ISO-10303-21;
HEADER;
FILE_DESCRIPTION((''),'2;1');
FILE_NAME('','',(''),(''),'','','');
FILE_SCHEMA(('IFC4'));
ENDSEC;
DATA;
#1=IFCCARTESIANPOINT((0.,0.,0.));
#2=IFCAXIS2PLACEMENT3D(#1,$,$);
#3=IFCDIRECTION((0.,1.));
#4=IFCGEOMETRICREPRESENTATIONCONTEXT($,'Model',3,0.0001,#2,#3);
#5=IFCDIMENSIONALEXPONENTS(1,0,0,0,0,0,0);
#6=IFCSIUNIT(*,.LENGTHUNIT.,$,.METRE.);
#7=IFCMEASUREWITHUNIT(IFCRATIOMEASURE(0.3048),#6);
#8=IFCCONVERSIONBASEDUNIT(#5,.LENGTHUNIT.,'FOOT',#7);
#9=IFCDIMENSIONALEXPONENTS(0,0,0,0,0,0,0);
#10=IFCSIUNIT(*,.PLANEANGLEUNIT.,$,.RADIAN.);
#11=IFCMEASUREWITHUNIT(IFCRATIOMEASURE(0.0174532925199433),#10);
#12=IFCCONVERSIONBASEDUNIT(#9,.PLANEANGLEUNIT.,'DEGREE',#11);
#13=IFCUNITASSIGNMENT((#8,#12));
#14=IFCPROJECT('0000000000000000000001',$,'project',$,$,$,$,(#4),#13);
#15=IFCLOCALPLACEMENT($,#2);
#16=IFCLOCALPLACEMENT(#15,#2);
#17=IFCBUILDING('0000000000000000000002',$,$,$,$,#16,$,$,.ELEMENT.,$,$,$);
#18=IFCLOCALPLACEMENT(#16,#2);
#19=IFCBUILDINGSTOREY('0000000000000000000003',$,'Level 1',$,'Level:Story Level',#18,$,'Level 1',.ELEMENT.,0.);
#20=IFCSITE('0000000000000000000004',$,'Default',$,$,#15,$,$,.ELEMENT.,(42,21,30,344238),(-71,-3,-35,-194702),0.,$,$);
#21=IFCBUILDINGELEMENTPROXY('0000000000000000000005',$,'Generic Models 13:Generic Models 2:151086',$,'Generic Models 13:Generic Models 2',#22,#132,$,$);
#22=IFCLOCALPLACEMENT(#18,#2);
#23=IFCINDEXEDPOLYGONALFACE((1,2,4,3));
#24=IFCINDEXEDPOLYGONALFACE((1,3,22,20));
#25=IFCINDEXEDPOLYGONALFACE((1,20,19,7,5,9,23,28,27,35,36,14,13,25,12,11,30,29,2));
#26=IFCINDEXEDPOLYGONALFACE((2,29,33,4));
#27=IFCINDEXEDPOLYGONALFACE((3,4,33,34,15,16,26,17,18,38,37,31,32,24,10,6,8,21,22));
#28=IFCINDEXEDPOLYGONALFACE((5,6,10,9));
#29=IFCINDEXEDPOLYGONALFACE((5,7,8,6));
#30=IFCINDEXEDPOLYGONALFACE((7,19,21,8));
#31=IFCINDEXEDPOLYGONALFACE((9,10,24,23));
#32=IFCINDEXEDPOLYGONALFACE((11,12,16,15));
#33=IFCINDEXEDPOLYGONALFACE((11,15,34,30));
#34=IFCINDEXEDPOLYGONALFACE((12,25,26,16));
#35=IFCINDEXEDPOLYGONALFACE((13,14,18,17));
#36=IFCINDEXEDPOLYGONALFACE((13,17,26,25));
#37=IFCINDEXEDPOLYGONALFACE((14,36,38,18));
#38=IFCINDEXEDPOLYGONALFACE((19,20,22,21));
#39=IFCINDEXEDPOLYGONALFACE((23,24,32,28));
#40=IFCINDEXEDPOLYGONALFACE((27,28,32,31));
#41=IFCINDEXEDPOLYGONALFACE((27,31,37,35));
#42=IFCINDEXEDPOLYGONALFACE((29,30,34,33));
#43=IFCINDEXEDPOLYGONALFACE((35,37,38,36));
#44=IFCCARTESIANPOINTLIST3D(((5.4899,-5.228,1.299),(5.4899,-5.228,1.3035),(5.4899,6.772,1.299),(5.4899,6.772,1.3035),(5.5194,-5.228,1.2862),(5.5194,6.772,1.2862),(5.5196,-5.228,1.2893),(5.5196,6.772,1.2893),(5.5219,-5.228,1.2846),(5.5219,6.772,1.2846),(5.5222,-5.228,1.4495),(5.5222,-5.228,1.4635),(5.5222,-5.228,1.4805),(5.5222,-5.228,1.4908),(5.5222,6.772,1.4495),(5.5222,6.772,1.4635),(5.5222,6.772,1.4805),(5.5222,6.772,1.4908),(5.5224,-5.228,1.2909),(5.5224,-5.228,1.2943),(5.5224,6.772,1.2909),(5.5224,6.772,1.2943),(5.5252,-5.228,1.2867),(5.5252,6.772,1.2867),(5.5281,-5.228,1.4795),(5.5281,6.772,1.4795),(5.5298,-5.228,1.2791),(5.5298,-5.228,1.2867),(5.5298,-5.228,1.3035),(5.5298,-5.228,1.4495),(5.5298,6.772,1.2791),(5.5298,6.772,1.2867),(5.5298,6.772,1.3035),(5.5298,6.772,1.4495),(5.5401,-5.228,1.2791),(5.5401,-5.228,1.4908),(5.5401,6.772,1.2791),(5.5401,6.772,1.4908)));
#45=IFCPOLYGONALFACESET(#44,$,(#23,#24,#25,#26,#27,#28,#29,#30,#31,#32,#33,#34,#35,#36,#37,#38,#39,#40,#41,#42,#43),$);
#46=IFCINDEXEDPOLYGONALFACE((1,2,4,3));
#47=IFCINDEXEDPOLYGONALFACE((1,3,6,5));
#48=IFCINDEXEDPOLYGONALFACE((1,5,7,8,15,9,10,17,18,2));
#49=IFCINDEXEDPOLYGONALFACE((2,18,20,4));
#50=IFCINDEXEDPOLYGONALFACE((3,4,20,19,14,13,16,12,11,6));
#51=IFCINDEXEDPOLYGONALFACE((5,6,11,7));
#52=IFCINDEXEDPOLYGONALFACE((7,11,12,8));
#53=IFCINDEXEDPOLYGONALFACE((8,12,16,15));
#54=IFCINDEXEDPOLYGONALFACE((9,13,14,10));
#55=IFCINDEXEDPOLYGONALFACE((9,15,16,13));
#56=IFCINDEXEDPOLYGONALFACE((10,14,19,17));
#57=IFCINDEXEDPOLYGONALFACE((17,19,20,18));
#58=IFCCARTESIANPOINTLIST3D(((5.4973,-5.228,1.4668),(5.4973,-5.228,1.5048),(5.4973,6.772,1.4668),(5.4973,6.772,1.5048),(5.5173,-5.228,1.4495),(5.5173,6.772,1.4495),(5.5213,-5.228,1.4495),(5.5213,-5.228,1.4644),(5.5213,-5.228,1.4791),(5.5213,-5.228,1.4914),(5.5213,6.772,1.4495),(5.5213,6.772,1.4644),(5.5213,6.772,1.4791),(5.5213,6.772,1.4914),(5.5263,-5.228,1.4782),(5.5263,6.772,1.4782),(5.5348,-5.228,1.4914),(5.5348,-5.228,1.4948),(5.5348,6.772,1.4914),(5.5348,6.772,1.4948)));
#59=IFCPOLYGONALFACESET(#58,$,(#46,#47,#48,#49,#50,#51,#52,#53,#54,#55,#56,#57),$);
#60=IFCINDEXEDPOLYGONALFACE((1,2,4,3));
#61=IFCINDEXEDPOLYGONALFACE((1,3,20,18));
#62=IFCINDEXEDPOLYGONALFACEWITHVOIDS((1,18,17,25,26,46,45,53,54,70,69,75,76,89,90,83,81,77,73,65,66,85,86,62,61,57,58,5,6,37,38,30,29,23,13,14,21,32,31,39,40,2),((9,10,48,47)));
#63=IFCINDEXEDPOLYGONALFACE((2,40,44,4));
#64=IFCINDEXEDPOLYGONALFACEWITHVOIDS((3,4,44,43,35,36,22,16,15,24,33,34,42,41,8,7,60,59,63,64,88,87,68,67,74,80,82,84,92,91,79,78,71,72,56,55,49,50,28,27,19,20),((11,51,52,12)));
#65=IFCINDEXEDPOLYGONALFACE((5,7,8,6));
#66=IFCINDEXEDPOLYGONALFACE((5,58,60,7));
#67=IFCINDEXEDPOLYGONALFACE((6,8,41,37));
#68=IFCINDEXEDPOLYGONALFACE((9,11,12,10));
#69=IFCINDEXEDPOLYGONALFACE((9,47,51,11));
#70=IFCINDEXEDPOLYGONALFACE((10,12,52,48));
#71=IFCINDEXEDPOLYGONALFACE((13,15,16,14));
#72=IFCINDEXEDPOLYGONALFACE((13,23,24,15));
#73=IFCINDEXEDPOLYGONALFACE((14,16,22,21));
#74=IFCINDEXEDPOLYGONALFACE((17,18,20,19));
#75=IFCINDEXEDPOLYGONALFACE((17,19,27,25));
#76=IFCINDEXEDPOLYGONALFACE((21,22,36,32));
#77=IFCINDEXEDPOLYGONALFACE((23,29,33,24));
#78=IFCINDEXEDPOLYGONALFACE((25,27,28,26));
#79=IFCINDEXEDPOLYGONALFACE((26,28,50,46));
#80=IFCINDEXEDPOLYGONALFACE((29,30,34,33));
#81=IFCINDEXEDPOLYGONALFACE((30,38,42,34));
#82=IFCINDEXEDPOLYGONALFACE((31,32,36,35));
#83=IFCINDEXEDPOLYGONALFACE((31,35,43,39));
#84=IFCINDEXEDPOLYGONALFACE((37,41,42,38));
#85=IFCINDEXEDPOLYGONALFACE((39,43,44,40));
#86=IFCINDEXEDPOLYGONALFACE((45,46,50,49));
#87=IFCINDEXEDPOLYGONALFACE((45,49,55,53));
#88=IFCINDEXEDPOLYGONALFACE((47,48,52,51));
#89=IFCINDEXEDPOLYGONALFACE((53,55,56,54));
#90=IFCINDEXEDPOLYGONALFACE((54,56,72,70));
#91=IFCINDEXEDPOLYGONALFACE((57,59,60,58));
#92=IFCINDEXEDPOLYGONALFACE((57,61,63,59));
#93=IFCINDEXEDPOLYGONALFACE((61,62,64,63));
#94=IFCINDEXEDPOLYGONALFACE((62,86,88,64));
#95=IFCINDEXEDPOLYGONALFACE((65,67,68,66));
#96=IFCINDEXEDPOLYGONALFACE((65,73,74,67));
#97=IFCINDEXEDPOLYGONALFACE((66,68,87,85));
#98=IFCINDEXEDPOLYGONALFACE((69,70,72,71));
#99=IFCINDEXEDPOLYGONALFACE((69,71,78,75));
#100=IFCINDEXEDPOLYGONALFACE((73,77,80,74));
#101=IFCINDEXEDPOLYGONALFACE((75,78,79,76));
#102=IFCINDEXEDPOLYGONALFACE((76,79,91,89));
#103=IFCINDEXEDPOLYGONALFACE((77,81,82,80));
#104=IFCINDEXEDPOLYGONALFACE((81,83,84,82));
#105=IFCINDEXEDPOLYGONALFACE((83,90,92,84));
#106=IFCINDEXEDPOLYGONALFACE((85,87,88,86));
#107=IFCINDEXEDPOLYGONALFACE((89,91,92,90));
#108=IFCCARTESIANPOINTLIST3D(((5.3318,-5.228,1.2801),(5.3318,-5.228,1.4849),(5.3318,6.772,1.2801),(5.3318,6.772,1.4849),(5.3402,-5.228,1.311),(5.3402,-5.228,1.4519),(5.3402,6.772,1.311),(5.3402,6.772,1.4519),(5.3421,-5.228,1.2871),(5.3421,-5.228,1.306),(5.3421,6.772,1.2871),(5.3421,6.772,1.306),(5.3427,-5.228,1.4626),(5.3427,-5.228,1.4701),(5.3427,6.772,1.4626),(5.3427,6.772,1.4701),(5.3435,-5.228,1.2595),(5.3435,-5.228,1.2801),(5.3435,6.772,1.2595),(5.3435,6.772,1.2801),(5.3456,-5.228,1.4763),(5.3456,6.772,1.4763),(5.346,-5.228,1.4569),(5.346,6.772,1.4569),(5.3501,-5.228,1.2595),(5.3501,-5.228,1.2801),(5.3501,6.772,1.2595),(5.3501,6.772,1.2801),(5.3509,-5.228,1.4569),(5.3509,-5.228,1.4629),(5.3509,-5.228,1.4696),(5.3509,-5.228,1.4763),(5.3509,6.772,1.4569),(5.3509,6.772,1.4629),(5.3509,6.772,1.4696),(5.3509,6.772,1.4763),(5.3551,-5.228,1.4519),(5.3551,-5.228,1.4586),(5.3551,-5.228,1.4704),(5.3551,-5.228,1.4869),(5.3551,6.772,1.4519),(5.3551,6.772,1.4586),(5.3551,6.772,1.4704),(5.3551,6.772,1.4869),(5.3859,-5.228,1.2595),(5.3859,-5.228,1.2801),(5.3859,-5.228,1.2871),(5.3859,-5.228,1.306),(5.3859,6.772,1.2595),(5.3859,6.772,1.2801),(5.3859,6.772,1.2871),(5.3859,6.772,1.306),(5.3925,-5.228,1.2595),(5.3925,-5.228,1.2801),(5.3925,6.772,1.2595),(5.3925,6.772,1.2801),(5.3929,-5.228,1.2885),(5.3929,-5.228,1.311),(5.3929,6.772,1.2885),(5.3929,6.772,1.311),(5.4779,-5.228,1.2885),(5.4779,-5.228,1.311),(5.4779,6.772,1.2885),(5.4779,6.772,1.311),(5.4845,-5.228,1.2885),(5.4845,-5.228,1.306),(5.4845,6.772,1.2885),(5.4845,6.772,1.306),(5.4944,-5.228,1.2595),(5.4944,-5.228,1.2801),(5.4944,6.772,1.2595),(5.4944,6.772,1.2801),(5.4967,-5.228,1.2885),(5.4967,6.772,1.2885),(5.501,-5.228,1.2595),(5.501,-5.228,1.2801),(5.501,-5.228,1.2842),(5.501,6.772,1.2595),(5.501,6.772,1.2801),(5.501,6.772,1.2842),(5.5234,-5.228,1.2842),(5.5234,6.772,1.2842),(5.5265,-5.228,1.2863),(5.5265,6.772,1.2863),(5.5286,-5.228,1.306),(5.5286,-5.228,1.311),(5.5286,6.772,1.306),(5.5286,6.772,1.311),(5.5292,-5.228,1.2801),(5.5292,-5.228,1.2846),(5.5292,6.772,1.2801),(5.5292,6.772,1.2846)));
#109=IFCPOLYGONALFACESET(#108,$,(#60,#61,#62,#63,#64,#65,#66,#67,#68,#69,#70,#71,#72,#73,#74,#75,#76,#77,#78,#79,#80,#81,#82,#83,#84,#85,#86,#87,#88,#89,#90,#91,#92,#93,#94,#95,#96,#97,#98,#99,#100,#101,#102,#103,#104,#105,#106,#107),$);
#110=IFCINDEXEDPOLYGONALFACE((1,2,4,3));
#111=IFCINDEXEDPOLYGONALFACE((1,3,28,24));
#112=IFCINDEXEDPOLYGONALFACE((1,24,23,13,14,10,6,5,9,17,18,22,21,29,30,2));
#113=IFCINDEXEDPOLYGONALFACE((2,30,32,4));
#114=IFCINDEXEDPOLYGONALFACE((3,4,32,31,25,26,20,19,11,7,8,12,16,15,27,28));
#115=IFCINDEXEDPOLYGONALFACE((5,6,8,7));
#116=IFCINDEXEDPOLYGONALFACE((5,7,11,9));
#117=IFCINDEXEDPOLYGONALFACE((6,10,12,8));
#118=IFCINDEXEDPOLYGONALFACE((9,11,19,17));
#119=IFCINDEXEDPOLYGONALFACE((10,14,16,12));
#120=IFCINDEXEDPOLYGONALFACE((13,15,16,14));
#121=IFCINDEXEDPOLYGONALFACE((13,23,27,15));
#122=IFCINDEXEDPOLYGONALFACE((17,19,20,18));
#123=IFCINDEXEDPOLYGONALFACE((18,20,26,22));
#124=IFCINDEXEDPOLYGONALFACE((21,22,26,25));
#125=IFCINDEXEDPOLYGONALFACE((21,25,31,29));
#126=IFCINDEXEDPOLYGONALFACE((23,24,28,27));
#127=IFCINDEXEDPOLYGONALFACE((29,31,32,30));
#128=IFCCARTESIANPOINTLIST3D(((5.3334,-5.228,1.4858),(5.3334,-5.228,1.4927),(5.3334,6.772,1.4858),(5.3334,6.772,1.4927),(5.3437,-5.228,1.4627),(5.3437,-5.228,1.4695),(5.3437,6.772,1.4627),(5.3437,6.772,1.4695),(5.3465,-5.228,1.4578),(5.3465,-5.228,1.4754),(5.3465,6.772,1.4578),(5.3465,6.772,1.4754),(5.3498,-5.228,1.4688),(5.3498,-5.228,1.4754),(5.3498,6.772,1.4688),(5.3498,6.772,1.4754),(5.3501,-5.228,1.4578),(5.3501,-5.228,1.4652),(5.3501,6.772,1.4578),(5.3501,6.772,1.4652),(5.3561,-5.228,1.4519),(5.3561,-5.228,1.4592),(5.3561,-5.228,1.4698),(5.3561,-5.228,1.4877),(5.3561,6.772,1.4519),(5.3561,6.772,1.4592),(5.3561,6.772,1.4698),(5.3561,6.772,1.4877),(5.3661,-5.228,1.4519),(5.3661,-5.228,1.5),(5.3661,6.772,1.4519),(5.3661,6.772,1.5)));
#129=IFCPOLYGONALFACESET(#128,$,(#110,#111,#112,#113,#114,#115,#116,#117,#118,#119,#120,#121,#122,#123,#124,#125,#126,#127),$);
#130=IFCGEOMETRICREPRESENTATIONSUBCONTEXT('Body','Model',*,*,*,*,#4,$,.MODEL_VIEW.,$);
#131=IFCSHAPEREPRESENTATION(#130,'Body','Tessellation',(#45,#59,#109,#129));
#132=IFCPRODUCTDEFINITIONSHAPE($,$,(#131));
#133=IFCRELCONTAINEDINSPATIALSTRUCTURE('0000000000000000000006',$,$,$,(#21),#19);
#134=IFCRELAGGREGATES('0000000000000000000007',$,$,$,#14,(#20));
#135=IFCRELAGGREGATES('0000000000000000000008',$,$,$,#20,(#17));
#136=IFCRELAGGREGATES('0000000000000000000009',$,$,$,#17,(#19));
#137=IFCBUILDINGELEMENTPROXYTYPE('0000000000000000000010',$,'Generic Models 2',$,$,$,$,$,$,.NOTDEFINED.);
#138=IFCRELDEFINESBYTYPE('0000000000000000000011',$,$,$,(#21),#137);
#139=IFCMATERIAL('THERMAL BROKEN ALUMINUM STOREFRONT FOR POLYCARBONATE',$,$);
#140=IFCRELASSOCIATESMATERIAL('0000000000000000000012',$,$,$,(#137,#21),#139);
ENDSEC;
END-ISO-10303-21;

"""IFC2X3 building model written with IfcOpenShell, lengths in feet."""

from ifc_helpers import new_model, entity, si_unit, converted_unit, direction, frame, origin, place, context, subcontext, project, spatial, polyline, outline, extrude, source, transform, mapped, material, type_object, type_shapes, element, save


model = new_model("IFC2X3")

# Units and contexts
model_context = context("Model", 3, precision=0.0001, world=origin(), true_north=direction((0.0, 1.0)))
body_context = subcontext(model_context, "Body", "Model", "MODEL_VIEW")
ifc_project = project(units=[converted_unit("LENGTHUNIT", "FOOT", entity("IfcRatioMeasure", 0.3048), si_unit("LENGTHUNIT", "METRE"), dimensions=[1, 0, 0, 0, 0, 0, 0]), converted_unit("PLANEANGLEUNIT", "DEGREE", entity("IfcRatioMeasure", 0.0174532925199433), si_unit("PLANEANGLEUNIT", "RADIAN"), dimensions=[0, 0, 0, 0, 0, 0, 0])], contexts=[model_context])

# Site, building, storey
site_placement = place(None, origin())
site = spatial("IfcSite", under=ifc_project, at=site_placement, Name="Default", CompositionType="ELEMENT", RefLatitude=(42, 21, 30, 344238), RefLongitude=(-71, -3, -35, -194702), RefElevation=0.0)
building_placement = place(site_placement, origin())
building = spatial("IfcBuilding", under=site, at=building_placement, CompositionType="ELEMENT")
storey_placement = place(building_placement, origin())
storey = spatial("IfcBuildingStorey", under=building, at=storey_placement, Name="Level 1", ObjectType="Level:Story Level", LongName="Level 1", CompositionType="ELEMENT", Elevation=0.0)

# Building element proxy
ifc_material = material(Name="THERMAL BROKEN ALUMINUM STOREFRONT FOR POLYCARBONATE")
building_element_proxy_type_1 = type_object("IfcBuildingElementProxyType", Name="Generic Models 2", PredefinedType="NOTDEFINED", material=ifc_material)
shared_shape_1 = source(origin(), body_context, "Body", "SweptSolid", [
    extrude(outline(polyline([(-0.0355, -0.058), (-0.0371, -0.0606), (-0.0358, -0.0632), (-0.0318, -0.063), (-0.0278, -0.0652), (-0.0315, -0.0718), (-0.0224, -0.0768), (0.0802, 0.1083), (0.0645, 0.1169), (0.0595, 0.1079), (0.0642, 0.1042), (0.0513, 0.0931), (0.0445, 0.0809), (0.0512, 0.0772), (-0.0197, -0.0506), (-0.0545, -0.0312), (-0.0567, -0.0352), (-0.0306, -0.055), (-0.0322, -0.058), (-0.0355, -0.058)])), frame((0.0, 1.2495, 0.3989), z_axis=(-1.0, 0.0, 0.0), x_axis=(0.0, -0.874529, 0.484974)), (0.0, 0.0, -1.0), 12.0),
    extrude(outline(polyline([(-0.0178, -0.0155), (-0.0144, -0.0155), (-0.0144, -0.002), (-0.0021, -0.002), (-0.0012, -0.007), (0.0126, -0.002), (0.0275, -0.002), (0.0275, 0.002), (0.0102, 0.022), (-0.0278, 0.022), (-0.0178, -0.0155)])), frame((0.0, 1.2527, 0.5187), z_axis=(1.0, 0.0, 0.0), x_axis=(0.0, 0.0, -1.0)), (0.0, 0.0, 1.0), 12.0),
    extrude(outline(polyline([(-0.107, -0.073), (-0.107, -0.058), (-0.1137, -0.058), (-0.118, -0.0623), (-0.1121, -0.0623), (-0.1121, -0.0672), (-0.1177, -0.0704), (-0.1252, -0.0704), (-0.1315, -0.0675), (-0.1315, -0.0623), (-0.1248, -0.0623), (-0.1255, -0.058), (-0.142, -0.058), (-0.1401, -0.0814), (0.0647, -0.0814), (0.0647, -0.0697), (0.0853, -0.0697), (0.0853, -0.0631), (0.0647, -0.0631), (0.0647, -0.0273), (0.0853, -0.0273), (0.0853, -0.0207), (0.0647, -0.0207), (0.0647, 0.0812), (0.0853, 0.0812), (0.0853, 0.0878), (0.0647, 0.0878), (0.0647, 0.1161), (0.0603, 0.1161), (0.0585, 0.1133), (0.0606, 0.1102), (0.0606, 0.0878), (0.0564, 0.0836), (0.0564, 0.0713), (0.0389, 0.0713), (0.0389, 0.1155), (0.0338, 0.1155), (0.0338, 0.0647), (0.0564, 0.0647), (0.0564, -0.0203), (0.0338, -0.0203), (0.0338, -0.073), (-0.107, -0.073)]), holes=[polyline([(0.0577, -0.0711), (0.0389, -0.0711), (0.0389, -0.0273), (0.0577, -0.0273), (0.0577, -0.0711)])]), frame((0.0, 1.3589, 0.3865), z_axis=(-1.0, 0.0, 0.0), x_axis=(0.0, 0.0, -1.0)), (0.0, 0.0, -1.0), 12.0),
    extrude(outline(polyline([(-0.0292, -0.0159), (0.0189, -0.0159), (0.0189, -0.0059), (0.0115, -0.0059), (0.0055, 0.0001), (0.0129, 0.0001), (0.0129, 0.0037), (0.008, 0.0065), (0.0012, 0.0065), (-0.0047, 0.0038), (-0.0047, 0.0004), (0.002, 0.0004), (0.0009, -0.0059), (-0.017, -0.0059), (-0.015, 0.0168), (-0.0219, 0.0168), (-0.0292, -0.0159)])), frame((0.0, 1.4218, 0.5124), z_axis=(1.0, 0.0, 0.0), x_axis=(0.0, 0.0, -1.0)), (0.0, 0.0, 1.0), 12.0),
])
type_shapes(building_element_proxy_type_1, [shared_shape_1])
proxy_1_placement = place(storey_placement, frame((6.772, -5.228, 0.9583), z_axis=(0.0, 0.0, 1.0), x_axis=(0.0, 1.0, 0.0)))
element("IfcBuildingElementProxy", 1, at=proxy_1_placement, inside=storey, type_object=building_element_proxy_type_1, material=ifc_material, Name="Generic Models 13:Generic Models 2:151086", ObjectType="Generic Models 13:Generic Models 2", context=body_context, shape_type="MappedRepresentation", body=[
    mapped(shared_shape_1, transform((0.0, 0.0, 0.0), scale=1.0)),
])

save(model, "model.ifc")
